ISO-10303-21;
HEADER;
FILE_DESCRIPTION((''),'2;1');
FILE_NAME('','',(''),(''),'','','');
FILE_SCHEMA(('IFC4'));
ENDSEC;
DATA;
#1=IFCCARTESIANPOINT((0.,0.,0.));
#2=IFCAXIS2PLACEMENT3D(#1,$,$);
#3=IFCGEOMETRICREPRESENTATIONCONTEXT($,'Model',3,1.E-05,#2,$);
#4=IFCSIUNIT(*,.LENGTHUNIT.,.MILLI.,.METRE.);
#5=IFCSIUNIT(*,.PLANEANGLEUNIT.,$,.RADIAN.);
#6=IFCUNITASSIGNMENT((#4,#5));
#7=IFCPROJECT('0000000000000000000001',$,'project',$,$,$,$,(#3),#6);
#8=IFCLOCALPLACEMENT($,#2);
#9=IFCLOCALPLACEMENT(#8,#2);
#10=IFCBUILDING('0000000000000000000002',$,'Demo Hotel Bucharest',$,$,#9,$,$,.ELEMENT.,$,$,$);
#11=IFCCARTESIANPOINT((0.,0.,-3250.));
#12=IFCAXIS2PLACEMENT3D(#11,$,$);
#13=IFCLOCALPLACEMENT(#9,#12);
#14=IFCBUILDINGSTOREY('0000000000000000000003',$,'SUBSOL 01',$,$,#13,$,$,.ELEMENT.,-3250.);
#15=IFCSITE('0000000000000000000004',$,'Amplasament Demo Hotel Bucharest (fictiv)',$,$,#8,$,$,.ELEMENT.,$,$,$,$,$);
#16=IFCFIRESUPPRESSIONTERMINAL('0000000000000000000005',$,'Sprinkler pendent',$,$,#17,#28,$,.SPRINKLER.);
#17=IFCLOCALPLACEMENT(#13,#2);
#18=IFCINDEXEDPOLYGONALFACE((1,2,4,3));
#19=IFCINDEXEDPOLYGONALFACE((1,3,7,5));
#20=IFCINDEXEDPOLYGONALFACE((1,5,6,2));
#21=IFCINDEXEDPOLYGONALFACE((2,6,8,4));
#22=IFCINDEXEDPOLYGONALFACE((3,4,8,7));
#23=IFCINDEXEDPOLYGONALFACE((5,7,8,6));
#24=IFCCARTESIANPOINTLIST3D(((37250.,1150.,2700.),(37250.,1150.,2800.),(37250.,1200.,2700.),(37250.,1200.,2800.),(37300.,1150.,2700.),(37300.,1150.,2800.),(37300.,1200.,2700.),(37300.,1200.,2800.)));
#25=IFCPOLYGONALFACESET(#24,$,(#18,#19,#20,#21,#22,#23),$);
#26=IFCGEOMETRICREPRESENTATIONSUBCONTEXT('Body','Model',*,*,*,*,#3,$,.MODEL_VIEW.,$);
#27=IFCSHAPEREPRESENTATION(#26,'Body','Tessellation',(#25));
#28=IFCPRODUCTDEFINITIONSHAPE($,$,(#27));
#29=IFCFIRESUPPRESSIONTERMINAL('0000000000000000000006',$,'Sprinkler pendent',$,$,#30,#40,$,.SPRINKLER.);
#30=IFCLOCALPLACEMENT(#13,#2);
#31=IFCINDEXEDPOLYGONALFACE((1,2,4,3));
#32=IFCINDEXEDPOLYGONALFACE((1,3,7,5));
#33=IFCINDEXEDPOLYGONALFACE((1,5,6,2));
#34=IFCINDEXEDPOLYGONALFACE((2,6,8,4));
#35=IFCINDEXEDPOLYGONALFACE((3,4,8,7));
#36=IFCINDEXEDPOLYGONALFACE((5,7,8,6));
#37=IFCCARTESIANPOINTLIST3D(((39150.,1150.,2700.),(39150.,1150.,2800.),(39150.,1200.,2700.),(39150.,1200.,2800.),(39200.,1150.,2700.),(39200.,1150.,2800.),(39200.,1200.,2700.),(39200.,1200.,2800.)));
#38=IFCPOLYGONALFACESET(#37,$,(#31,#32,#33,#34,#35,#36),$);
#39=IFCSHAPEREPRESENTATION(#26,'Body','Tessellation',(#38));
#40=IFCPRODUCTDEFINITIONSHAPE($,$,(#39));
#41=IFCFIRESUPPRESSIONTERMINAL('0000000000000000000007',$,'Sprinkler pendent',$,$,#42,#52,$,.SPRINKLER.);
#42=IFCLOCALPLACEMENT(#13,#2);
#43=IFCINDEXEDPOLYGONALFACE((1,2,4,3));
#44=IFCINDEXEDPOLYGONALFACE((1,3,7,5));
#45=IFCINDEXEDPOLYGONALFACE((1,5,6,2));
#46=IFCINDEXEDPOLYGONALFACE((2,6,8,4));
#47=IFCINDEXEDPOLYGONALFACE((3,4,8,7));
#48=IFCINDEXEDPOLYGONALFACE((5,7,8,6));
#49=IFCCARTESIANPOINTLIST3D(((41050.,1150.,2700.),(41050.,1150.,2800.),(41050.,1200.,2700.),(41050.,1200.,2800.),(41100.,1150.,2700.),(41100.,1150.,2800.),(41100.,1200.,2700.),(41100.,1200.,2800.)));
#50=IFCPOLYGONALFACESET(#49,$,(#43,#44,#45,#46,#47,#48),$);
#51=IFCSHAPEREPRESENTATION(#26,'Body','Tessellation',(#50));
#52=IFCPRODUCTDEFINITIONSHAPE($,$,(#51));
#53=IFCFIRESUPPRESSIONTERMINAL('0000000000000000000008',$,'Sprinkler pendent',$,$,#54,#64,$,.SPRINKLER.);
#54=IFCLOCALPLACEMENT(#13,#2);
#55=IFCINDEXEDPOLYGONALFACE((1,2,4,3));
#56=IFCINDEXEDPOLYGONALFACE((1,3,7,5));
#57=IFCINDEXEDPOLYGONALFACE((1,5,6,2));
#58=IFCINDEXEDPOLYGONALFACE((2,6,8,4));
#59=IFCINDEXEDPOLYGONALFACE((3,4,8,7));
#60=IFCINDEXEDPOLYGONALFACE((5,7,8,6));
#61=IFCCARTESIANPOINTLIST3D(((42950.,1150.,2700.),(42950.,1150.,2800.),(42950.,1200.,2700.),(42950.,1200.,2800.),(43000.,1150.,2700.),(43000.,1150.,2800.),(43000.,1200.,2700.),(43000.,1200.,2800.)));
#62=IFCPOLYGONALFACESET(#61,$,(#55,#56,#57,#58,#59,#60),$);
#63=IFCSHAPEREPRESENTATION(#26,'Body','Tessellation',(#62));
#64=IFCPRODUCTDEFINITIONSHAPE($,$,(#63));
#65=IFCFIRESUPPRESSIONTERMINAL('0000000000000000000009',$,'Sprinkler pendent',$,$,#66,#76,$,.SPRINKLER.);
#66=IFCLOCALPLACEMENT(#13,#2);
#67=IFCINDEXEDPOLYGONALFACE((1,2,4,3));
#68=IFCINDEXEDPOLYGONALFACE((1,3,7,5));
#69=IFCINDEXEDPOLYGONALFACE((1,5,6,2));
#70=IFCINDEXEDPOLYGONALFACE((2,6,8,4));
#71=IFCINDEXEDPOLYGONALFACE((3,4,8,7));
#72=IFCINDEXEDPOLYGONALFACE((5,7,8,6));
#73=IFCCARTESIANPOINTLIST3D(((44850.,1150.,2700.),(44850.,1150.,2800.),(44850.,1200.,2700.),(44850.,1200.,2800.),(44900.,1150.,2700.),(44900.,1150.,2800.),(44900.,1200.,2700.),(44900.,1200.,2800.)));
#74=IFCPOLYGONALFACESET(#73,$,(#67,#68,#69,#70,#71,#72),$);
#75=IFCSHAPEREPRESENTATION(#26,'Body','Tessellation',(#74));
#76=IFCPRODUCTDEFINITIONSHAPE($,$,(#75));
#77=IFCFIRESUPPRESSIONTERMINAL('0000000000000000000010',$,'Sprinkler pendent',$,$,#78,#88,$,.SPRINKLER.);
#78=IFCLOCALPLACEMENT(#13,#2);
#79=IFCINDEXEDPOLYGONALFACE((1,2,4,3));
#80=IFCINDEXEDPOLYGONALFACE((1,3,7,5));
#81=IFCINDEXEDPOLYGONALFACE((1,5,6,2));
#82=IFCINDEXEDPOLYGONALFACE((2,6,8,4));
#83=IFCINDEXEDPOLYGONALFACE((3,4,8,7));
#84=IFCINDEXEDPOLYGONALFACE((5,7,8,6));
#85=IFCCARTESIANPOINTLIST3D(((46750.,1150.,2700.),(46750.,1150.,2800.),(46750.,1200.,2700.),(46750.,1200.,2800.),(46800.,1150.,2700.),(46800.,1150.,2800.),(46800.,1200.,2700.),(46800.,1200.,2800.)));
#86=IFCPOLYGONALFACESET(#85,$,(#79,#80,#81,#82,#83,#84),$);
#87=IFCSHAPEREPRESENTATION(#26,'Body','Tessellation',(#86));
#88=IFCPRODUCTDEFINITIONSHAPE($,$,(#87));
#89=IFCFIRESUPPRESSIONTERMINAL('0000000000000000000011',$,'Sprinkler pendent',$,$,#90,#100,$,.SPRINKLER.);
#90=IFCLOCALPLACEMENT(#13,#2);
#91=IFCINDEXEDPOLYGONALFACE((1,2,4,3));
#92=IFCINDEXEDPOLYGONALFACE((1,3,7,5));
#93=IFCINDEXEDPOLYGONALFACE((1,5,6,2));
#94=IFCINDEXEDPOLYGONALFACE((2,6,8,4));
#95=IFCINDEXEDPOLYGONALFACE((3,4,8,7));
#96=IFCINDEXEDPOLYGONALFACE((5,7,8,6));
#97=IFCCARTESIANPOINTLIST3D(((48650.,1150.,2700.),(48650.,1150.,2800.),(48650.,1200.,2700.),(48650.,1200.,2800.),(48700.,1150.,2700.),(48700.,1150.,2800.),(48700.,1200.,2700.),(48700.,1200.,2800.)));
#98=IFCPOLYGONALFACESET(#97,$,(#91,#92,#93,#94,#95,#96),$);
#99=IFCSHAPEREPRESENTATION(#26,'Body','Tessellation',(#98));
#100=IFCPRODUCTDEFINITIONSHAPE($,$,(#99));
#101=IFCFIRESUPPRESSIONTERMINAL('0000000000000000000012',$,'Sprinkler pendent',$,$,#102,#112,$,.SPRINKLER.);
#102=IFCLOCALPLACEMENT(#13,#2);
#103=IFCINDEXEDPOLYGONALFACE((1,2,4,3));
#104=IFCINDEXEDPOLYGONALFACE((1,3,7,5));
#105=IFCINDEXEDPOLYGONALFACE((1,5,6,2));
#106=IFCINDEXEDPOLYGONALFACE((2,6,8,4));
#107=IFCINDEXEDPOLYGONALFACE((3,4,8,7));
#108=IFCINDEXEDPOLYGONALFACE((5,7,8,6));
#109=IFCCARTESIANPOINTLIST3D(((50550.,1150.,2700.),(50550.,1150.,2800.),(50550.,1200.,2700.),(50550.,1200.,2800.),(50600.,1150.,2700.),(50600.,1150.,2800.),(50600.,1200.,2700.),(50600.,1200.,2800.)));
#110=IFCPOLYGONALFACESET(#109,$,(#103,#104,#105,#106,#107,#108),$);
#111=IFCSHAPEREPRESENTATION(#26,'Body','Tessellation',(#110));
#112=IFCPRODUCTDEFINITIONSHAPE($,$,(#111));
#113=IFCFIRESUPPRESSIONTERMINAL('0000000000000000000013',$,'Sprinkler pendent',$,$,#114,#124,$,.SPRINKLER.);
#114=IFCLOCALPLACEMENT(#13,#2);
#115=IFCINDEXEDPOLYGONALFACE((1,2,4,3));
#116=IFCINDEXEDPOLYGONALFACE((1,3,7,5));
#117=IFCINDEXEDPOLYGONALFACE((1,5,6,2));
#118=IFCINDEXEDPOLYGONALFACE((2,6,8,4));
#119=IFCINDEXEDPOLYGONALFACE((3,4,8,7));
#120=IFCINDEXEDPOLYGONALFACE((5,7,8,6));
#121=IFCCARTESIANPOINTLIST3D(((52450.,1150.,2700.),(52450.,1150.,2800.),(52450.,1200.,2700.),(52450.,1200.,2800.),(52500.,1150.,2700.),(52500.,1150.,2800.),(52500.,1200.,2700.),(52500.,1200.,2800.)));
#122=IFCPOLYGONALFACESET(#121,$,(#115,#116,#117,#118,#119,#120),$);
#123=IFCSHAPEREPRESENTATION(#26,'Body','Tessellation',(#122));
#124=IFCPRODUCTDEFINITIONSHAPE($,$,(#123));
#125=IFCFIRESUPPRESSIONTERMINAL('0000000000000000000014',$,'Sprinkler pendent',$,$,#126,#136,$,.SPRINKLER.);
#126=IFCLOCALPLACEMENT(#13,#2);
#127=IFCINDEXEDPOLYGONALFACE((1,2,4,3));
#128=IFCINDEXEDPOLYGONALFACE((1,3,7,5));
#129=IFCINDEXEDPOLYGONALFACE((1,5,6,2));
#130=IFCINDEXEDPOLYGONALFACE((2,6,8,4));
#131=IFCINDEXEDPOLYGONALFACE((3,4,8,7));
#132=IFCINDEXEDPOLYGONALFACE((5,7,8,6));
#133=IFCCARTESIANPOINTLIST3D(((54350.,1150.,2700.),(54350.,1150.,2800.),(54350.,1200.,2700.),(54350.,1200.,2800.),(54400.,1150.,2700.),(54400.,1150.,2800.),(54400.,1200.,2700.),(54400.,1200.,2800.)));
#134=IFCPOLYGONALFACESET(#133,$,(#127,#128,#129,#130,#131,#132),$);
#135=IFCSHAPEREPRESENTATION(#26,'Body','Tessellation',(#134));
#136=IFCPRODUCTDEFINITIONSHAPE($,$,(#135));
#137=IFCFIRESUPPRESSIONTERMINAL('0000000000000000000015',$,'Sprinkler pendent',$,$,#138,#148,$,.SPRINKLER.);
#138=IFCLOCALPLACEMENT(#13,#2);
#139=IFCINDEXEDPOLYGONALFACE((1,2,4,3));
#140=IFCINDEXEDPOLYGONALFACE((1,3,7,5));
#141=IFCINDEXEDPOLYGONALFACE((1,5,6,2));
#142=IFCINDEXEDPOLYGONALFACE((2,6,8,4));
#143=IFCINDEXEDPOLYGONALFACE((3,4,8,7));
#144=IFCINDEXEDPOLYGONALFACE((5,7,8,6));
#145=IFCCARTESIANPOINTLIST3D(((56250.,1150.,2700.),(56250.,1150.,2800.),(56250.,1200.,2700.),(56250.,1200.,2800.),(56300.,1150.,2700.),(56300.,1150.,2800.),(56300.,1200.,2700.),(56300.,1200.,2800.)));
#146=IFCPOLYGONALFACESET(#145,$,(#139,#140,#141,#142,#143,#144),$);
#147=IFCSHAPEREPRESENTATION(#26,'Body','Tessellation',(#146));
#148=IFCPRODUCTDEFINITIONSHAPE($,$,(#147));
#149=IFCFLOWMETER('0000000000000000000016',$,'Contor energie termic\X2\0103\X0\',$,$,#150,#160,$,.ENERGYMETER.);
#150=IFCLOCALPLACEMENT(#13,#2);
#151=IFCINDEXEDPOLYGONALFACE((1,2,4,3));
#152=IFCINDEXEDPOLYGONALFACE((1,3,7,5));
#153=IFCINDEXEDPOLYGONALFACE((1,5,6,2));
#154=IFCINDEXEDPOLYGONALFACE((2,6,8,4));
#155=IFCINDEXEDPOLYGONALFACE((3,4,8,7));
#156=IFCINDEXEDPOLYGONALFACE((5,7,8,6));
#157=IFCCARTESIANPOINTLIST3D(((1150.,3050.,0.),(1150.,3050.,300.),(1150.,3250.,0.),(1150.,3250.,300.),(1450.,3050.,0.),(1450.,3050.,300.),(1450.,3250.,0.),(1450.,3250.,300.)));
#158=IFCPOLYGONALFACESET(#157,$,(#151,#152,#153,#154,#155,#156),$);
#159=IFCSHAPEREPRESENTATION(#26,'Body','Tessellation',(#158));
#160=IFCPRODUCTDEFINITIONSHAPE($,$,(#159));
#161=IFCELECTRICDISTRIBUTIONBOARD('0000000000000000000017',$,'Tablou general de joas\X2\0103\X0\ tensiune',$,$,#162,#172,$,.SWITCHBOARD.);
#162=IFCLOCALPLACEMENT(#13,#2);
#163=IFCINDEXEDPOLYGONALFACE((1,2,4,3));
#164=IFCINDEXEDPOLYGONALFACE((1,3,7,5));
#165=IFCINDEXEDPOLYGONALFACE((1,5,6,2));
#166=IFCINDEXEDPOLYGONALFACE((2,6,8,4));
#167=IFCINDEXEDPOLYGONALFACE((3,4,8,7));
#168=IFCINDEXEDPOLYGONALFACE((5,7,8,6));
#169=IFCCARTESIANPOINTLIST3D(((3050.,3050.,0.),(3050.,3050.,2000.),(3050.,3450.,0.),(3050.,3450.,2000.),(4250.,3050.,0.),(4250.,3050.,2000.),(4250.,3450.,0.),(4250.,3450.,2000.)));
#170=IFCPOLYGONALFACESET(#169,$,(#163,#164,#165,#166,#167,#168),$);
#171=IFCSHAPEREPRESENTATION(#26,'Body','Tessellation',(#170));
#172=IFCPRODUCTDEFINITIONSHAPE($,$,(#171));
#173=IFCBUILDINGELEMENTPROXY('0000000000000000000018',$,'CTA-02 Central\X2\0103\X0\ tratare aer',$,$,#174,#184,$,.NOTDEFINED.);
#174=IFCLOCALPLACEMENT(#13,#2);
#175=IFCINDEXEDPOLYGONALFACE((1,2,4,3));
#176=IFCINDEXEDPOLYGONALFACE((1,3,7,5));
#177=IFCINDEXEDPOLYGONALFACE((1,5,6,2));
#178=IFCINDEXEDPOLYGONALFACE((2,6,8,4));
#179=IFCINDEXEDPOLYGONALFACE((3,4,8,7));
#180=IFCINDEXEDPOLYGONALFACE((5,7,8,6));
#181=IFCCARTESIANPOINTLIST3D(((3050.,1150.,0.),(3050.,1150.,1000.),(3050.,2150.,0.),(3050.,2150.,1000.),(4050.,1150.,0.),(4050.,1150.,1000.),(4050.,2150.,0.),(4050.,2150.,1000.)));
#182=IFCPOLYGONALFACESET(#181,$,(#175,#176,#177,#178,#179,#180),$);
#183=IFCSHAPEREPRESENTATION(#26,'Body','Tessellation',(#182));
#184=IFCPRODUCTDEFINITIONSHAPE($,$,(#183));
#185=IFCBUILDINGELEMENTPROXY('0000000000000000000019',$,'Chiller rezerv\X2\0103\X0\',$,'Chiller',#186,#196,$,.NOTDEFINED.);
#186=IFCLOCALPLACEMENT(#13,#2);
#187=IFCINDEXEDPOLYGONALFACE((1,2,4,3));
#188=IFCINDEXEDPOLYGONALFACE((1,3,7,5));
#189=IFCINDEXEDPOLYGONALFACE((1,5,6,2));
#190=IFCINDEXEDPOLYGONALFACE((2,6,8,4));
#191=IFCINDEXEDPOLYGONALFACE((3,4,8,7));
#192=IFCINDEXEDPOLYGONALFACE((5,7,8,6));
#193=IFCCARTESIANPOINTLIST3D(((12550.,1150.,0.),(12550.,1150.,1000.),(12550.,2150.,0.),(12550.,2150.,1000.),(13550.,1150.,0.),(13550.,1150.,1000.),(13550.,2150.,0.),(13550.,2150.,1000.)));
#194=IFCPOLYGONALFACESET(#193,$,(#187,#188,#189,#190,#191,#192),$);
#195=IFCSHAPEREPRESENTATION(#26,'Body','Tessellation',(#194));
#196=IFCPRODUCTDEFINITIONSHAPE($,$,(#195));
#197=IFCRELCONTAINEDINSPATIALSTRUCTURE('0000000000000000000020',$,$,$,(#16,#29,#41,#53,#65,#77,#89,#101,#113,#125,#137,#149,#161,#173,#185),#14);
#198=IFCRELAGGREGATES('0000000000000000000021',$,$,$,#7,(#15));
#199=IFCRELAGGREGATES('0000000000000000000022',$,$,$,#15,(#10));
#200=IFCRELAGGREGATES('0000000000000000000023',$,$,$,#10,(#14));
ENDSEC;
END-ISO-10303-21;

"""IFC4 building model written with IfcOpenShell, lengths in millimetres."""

from ifc_helpers import new_model, si_unit, frame, frame_2d, origin, place, context, subcontext, project, spatial, rectangle, extrude, element, save


model = new_model("IFC4")

# Units and contexts
model_context = context("Model", 3, precision=1e-05, world=origin())
body_context = subcontext(model_context, "Body", "Model", "MODEL_VIEW")
ifc_project = project(units=[si_unit("LENGTHUNIT", "METRE", prefix="MILLI"), si_unit("PLANEANGLEUNIT", "RADIAN")], contexts=[model_context])

# Site, building, storey
site_placement = place(None, origin())
site = spatial("IfcSite", under=ifc_project, at=site_placement, Name="Amplasament Demo Hotel Bucharest (fictiv)", CompositionType="ELEMENT")
building_placement = place(site_placement, origin())
building = spatial("IfcBuilding", under=site, at=building_placement, Name="Demo Hotel Bucharest", CompositionType="ELEMENT")
storey_placement = place(building_placement, frame((0.0, 0.0, -3250.0)))
storey = spatial("IfcBuildingStorey", under=building, at=storey_placement, Name="SUBSOL 01", CompositionType="ELEMENT", Elevation=-3250.0)

# Fire suppression terminals
for number, where, name in (
    (1, (37250.0, 1150.0, 2700.0), "Sprinkler pendent"),
    (2, (39150.0, 1150.0, 2700.0), "Sprinkler pendent"),
    (3, (41050.0, 1150.0, 2700.0), "Sprinkler pendent"),
    (4, (42950.0, 1150.0, 2700.0), "Sprinkler pendent"),
    (5, (44850.0, 1150.0, 2700.0), "Sprinkler pendent"),
    (6, (46750.0, 1150.0, 2700.0), "Sprinkler pendent"),
    (7, (48650.0, 1150.0, 2700.0), "Sprinkler pendent"),
    (8, (50550.0, 1150.0, 2700.0), "Sprinkler pendent"),
    (9, (52450.0, 1150.0, 2700.0), "Sprinkler pendent"),
    (10, (54350.0, 1150.0, 2700.0), "Sprinkler pendent"),
    (11, (56250.0, 1150.0, 2700.0), "Sprinkler pendent"),
):
    element("IfcFireSuppressionTerminal", number, at=place(storey_placement, frame(where)), inside=storey, Name=name, PredefinedType="SPRINKLER", context=body_context, shape_type="SweptSolid", body=[
        extrude(rectangle(XDim=50.0, YDim=50.0, at=frame_2d((25.0, 25.0))), origin(), (0.0, 0.0, 1.0), 100.0),
    ])

# Flow meter
flow_meter_placement = place(storey_placement, frame((1150.0, 3050.0, 0.0)))
element("IfcFlowMeter", 12, at=flow_meter_placement, inside=storey, Name="Contor energie termică", PredefinedType="ENERGYMETER", context=body_context, shape_type="SweptSolid", body=[
    extrude(rectangle(XDim=300.0, YDim=200.0, at=frame_2d((150.0, 100.0))), origin(), (0.0, 0.0, 1.0), 300.0),
])

# Electric distribution board
electric_distribution_board_placement = place(storey_placement, frame((3050.0, 3050.0, 0.0)))
element("IfcElectricDistributionBoard", 13, at=electric_distribution_board_placement, inside=storey, Name="Tablou general de joasă tensiune", PredefinedType="SWITCHBOARD", context=body_context, shape_type="SweptSolid", body=[
    extrude(rectangle(XDim=1200.0, YDim=400.0, at=frame_2d((600.0, 200.0))), origin(), (0.0, 0.0, 1.0), 2000.0),
])

# Building element proxies
proxy_1_placement = place(storey_placement, frame((3050.0, 1150.0, 0.0)))
element("IfcBuildingElementProxy", 14, at=proxy_1_placement, inside=storey, Name="CTA-02 Centrală tratare aer", PredefinedType="NOTDEFINED", context=body_context, shape_type="SweptSolid", body=[
    extrude(rectangle(XDim=1000.0, YDim=1000.0, at=frame_2d((500.0, 500.0))), origin(), (0.0, 0.0, 1.0), 1000.0),
])
proxy_2_placement = place(storey_placement, frame((12550.0, 1150.0, 0.0)))
element("IfcBuildingElementProxy", 15, at=proxy_2_placement, inside=storey, Name="Chiller rezervă", ObjectType="Chiller", PredefinedType="NOTDEFINED", context=body_context, shape_type="SweptSolid", body=[
    extrude(rectangle(XDim=1000.0, YDim=1000.0, at=frame_2d((500.0, 500.0))), origin(), (0.0, 0.0, 1.0), 1000.0),
])

save(model, "model.ifc")
